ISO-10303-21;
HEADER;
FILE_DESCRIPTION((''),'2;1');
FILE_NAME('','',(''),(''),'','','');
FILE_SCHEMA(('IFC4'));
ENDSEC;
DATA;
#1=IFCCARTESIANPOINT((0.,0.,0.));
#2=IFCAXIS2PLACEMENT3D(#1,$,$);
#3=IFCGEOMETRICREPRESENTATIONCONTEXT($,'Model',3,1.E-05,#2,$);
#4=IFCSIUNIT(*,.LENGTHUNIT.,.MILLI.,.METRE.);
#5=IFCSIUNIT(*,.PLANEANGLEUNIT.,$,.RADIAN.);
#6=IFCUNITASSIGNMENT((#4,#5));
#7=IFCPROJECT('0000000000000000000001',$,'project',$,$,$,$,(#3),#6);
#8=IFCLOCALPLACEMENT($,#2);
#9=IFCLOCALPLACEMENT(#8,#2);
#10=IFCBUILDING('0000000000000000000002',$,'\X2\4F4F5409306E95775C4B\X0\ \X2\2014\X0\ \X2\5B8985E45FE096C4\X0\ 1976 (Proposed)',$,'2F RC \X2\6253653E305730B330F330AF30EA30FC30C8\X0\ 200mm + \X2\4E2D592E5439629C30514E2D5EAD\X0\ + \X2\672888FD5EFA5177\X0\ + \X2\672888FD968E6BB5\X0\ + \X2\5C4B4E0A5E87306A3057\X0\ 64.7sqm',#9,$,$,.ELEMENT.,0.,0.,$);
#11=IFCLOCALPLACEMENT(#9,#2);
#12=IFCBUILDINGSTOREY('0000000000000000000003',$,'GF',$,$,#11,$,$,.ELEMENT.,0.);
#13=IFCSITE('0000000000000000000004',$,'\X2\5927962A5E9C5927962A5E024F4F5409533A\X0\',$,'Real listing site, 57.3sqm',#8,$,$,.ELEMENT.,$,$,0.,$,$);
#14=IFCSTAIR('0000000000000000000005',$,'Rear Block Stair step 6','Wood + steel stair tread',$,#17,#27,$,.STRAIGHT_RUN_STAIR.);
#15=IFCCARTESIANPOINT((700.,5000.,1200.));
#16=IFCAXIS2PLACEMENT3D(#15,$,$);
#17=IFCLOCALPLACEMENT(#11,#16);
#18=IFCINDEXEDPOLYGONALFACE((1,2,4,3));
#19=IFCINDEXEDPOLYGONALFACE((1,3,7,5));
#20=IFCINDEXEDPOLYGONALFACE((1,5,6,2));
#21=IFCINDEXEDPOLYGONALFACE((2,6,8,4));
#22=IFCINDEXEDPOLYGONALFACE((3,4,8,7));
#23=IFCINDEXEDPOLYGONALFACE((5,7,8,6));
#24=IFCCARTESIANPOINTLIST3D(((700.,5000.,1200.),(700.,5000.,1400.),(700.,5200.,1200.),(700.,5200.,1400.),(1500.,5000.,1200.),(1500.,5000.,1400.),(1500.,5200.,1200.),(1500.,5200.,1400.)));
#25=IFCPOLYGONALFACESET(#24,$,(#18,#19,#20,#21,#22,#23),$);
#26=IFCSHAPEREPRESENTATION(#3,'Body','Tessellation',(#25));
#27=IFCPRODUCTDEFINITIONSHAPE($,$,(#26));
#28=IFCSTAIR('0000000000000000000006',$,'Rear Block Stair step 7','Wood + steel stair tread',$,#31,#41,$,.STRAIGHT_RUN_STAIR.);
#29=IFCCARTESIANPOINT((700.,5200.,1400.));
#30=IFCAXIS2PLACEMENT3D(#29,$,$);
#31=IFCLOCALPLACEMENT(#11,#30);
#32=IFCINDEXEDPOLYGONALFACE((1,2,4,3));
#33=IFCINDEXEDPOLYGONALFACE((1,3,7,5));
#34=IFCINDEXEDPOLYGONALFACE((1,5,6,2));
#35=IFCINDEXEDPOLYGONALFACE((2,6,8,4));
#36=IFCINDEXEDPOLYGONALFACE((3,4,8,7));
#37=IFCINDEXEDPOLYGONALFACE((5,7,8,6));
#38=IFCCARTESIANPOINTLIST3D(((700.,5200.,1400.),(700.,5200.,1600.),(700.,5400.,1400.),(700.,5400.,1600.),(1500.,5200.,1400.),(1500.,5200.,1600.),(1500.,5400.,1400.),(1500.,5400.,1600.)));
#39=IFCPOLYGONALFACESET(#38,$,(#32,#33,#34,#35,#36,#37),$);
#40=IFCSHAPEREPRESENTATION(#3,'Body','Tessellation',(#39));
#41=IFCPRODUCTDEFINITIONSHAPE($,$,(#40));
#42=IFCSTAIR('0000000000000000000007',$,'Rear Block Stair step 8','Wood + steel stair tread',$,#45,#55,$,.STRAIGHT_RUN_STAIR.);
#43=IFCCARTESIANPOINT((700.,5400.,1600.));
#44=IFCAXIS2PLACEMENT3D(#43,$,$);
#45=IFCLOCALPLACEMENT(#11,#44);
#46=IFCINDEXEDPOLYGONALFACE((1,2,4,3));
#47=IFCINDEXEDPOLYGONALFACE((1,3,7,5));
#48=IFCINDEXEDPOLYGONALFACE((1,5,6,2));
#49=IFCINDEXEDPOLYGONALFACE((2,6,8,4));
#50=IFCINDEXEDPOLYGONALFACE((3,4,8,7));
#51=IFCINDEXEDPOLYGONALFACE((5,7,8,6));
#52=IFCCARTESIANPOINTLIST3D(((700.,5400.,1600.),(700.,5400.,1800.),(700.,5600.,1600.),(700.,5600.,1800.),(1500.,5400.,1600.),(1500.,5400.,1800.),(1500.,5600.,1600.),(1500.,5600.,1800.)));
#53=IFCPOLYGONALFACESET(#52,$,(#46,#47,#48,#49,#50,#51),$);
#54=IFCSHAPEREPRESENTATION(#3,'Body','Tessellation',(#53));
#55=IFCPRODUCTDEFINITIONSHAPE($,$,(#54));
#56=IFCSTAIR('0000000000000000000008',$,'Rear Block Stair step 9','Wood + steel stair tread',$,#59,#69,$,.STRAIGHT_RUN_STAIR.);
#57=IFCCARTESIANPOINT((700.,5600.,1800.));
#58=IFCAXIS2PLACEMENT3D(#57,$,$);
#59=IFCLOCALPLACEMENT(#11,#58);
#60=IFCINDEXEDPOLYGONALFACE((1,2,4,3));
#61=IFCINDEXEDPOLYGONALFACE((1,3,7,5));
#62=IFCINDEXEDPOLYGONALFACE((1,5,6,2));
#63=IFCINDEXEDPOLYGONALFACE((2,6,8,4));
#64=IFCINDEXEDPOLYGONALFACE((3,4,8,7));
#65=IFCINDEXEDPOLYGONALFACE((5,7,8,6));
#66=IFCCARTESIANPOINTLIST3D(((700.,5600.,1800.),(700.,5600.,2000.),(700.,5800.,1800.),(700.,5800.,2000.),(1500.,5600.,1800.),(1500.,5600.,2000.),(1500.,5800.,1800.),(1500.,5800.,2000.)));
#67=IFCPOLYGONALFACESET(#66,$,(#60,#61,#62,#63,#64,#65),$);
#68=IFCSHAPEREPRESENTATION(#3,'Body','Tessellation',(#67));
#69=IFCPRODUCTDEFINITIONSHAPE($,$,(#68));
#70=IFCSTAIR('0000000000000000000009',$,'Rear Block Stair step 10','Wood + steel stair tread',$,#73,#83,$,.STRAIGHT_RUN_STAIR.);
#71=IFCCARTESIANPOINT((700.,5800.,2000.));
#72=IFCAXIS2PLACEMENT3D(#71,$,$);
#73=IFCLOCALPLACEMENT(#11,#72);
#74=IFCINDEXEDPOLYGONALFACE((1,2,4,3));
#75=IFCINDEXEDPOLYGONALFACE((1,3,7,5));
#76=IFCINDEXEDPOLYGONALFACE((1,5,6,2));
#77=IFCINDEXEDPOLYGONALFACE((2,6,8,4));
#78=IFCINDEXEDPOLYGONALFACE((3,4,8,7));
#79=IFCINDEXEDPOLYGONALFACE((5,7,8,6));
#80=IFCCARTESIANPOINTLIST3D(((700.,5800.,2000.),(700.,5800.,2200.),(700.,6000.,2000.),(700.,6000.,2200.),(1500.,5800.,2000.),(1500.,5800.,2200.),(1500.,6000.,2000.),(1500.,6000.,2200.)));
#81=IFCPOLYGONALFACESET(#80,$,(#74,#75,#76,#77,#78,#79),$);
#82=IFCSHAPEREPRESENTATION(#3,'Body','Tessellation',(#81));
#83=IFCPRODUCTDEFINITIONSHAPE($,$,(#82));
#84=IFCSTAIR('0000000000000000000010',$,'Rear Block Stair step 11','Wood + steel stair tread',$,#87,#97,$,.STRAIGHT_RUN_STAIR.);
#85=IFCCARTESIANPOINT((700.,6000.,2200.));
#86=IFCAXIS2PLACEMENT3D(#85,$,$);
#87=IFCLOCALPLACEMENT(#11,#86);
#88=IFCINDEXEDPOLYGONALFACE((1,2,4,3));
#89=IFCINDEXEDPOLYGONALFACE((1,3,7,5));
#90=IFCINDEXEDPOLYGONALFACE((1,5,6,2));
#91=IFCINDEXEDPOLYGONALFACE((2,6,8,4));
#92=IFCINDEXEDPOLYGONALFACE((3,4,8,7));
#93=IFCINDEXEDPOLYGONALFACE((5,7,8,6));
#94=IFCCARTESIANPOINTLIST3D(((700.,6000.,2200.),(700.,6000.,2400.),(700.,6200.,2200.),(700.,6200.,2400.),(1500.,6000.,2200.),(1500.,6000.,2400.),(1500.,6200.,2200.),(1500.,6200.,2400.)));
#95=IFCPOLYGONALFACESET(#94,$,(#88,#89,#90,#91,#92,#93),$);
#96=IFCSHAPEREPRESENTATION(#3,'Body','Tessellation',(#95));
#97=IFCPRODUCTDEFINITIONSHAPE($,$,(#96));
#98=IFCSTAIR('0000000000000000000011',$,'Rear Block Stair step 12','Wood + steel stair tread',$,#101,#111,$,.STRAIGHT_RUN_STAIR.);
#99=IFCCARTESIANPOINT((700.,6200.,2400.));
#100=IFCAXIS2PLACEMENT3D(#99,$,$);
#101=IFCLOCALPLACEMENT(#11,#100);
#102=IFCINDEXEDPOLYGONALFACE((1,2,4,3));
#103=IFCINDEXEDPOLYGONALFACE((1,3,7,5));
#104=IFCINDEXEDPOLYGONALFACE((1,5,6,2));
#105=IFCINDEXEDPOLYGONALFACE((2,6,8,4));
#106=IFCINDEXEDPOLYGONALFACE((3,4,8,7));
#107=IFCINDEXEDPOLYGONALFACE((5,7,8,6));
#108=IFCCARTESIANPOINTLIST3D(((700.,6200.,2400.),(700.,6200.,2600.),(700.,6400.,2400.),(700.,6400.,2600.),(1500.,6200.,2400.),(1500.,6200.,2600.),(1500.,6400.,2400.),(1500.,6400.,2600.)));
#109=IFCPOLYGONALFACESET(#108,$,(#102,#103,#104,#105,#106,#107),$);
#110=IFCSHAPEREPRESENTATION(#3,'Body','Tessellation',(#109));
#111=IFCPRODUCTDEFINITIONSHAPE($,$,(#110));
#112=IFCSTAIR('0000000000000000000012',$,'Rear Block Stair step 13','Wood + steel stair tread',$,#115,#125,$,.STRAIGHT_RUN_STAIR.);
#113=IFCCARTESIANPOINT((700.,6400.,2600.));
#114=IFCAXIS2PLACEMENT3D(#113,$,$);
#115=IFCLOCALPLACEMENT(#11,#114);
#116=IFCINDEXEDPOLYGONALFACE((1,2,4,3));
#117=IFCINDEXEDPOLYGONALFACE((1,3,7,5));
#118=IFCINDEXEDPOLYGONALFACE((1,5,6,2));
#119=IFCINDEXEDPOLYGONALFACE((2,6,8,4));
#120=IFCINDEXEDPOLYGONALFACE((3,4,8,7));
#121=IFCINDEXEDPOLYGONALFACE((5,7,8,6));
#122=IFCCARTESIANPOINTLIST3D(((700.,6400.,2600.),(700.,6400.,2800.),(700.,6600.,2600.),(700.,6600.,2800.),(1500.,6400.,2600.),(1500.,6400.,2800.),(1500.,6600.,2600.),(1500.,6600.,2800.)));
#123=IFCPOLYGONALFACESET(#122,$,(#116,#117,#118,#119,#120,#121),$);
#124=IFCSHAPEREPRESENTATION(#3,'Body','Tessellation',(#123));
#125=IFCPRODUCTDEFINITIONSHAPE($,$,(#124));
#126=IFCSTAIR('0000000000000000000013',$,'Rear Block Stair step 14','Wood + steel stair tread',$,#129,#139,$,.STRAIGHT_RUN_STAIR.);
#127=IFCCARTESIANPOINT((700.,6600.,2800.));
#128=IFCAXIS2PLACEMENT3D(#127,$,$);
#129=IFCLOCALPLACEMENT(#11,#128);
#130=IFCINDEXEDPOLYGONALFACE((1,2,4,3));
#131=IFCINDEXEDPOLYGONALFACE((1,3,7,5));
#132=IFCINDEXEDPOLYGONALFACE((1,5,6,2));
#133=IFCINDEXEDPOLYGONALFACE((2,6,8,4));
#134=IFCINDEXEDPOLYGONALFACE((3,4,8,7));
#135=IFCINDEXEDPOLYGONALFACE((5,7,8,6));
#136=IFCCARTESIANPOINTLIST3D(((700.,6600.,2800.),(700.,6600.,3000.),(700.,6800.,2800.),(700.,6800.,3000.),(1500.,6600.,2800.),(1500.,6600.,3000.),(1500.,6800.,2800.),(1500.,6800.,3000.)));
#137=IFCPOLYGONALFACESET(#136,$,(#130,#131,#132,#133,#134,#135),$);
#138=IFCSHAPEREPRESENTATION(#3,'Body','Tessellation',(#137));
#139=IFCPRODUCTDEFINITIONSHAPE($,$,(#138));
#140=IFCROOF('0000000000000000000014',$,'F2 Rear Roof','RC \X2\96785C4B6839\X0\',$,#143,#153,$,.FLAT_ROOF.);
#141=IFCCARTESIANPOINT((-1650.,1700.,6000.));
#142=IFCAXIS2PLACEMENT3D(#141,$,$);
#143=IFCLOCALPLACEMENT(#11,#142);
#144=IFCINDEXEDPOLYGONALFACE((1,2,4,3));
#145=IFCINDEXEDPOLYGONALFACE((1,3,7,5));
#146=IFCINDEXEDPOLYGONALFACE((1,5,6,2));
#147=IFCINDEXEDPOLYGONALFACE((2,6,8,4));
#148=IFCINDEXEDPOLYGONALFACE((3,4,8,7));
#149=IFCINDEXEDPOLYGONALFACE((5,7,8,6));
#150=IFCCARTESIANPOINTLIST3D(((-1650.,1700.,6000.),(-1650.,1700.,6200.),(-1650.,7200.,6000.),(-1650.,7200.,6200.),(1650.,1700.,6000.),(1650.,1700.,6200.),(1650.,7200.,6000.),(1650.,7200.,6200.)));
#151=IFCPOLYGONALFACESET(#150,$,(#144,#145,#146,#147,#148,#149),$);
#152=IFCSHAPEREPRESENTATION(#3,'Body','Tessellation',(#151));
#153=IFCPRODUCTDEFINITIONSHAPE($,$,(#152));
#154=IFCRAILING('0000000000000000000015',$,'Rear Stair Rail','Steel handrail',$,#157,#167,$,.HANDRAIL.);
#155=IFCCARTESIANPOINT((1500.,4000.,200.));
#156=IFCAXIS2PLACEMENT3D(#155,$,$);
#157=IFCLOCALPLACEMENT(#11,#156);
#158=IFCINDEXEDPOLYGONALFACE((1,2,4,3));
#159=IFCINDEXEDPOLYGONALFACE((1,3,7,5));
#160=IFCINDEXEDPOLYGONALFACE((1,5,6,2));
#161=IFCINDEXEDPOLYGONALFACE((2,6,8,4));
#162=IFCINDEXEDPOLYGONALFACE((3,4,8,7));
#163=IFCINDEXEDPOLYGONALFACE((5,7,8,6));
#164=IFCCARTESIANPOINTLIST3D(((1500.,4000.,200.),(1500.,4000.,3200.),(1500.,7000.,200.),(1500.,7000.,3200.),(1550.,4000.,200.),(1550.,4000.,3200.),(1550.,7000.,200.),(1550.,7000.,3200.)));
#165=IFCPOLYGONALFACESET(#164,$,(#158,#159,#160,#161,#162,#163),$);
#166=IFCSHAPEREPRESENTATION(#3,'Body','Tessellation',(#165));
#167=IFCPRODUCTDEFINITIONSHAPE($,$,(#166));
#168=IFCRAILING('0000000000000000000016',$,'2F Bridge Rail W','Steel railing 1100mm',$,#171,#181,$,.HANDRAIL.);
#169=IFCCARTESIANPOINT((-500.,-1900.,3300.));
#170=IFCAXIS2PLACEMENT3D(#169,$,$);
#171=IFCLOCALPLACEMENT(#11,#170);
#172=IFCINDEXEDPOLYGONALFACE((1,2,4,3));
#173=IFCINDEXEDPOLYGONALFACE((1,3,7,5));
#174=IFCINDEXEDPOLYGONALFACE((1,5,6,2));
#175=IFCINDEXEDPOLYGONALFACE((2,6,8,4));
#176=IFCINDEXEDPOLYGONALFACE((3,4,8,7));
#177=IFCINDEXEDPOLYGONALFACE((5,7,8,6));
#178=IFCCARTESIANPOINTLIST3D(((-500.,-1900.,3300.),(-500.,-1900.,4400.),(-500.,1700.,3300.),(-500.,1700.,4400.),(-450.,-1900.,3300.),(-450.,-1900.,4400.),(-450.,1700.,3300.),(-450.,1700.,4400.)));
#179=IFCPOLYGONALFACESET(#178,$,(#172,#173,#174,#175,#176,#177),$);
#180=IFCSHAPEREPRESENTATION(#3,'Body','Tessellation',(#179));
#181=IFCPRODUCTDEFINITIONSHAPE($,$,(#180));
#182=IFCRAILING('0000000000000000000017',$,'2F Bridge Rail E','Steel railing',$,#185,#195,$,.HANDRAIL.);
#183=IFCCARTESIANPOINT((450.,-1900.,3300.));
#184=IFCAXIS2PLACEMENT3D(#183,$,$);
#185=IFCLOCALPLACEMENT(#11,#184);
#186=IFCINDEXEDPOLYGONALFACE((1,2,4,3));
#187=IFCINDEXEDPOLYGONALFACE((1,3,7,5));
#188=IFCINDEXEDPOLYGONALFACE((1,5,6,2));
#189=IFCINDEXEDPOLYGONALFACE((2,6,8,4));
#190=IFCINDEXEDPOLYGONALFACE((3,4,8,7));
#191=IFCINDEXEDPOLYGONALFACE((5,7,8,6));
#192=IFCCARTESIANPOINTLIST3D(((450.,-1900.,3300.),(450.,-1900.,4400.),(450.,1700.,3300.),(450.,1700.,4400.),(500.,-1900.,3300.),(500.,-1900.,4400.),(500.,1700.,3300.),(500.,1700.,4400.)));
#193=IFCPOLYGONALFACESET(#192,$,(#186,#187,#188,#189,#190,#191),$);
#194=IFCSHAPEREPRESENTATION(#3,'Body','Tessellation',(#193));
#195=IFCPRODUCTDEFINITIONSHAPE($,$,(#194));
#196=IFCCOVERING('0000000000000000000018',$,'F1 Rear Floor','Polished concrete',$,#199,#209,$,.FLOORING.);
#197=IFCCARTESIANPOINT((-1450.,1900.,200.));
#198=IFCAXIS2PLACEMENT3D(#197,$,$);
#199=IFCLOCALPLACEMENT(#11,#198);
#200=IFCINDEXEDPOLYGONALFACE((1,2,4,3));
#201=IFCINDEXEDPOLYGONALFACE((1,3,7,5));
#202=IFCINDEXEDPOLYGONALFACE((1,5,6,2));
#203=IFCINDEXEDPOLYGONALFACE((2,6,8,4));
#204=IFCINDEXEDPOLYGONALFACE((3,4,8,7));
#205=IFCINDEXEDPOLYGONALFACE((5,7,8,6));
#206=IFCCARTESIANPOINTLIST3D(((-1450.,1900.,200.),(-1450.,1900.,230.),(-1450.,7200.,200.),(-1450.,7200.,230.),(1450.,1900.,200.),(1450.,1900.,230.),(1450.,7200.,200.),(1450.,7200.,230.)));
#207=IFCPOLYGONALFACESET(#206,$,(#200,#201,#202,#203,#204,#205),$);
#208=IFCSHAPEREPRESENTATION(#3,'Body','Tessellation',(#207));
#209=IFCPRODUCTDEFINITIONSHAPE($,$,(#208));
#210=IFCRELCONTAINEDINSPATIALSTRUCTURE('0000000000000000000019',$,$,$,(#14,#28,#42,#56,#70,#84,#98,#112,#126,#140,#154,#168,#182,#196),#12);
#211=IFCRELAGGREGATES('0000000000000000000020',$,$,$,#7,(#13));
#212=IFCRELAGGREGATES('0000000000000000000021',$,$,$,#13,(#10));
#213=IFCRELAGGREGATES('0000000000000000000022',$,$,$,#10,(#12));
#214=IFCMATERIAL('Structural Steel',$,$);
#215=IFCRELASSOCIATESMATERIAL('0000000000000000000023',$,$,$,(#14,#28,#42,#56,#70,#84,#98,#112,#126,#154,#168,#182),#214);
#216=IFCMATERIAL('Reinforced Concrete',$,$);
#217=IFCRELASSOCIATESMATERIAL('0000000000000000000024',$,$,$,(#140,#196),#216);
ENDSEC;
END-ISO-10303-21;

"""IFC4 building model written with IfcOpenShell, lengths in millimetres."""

from ifc_helpers import new_model, si_unit, frame, frame_2d, origin, place, context, project, spatial, rectangle, extrude, material, element, save


model = new_model("IFC4")

# Units and contexts
model_context = context("Model", 3, precision=1e-05, world=origin())
ifc_project = project(units=[si_unit("LENGTHUNIT", "METRE", prefix="MILLI"), si_unit("PLANEANGLEUNIT", "RADIAN")], contexts=[model_context])

# Site, building, storey
site_placement = place(None, origin())
site = spatial("IfcSite", under=ifc_project, at=site_placement, Name="大阪府大阪市住吉区", ObjectType="Real listing site, 57.3sqm", CompositionType="ELEMENT", RefElevation=0.0)
building_placement = place(site_placement, origin())
building = spatial("IfcBuilding", under=site, at=building_placement, Name="住吉の長屋 — 安藤忠雄 1976 (Proposed)", ObjectType="2F RC 打放しコンクリート 200mm + 中央吹抜け中庭 + 木製建具 + 木製階段 + 屋上庇なし 64.7sqm", CompositionType="ELEMENT", ElevationOfRefHeight=0.0, ElevationOfTerrain=0.0)
storey_placement = place(building_placement, origin())
storey = spatial("IfcBuildingStorey", under=building, at=storey_placement, Name="GF", CompositionType="ELEMENT", Elevation=0.0)

# Shared definitions
ifc_material_1 = material(Name="Reinforced Concrete")

# Stairs
ifc_material_2 = material(Name="Structural Steel")
stair_1_placement = place(storey_placement, frame((700.0, 5000.0, 1200.0)))
element("IfcStair", 1, at=stair_1_placement, inside=storey, material=ifc_material_2, Name="Rear Block Stair step 6", Description="Wood + steel stair tread", PredefinedType="STRAIGHT_RUN_STAIR", context=model_context, shape_type="SweptSolid", body=[
    extrude(rectangle(XDim=800.0, YDim=200.0, at=frame_2d((400.0, 100.0))), frame((700.0, 5000.0, 1200.0)), (0.0, 0.0, 1.0), 200.0),
])
stair_2_placement = place(storey_placement, frame((700.0, 5200.0, 1400.0)))
element("IfcStair", 2, at=stair_2_placement, inside=storey, material=ifc_material_2, Name="Rear Block Stair step 7", Description="Wood + steel stair tread", PredefinedType="STRAIGHT_RUN_STAIR", context=model_context, shape_type="SweptSolid", body=[
    extrude(rectangle(XDim=800.0, YDim=200.0, at=frame_2d((400.0, 100.0))), frame((700.0, 5200.0, 1400.0)), (0.0, 0.0, 1.0), 200.0),
])
stair_3_placement = place(storey_placement, frame((700.0, 5400.0, 1600.0)))
element("IfcStair", 3, at=stair_3_placement, inside=storey, material=ifc_material_2, Name="Rear Block Stair step 8", Description="Wood + steel stair tread", PredefinedType="STRAIGHT_RUN_STAIR", context=model_context, shape_type="SweptSolid", body=[
    extrude(rectangle(XDim=800.0, YDim=200.0, at=frame_2d((400.0, 100.0))), frame((700.0, 5400.0, 1600.0)), (0.0, 0.0, 1.0), 200.0),
])
stair_4_placement = place(storey_placement, frame((700.0, 5600.0, 1800.0)))
element("IfcStair", 4, at=stair_4_placement, inside=storey, material=ifc_material_2, Name="Rear Block Stair step 9", Description="Wood + steel stair tread", PredefinedType="STRAIGHT_RUN_STAIR", context=model_context, shape_type="SweptSolid", body=[
    extrude(rectangle(XDim=800.0, YDim=200.0, at=frame_2d((400.0, 100.0))), frame((700.0, 5600.0, 1800.0)), (0.0, 0.0, 1.0), 200.0),
])
stair_5_placement = place(storey_placement, frame((700.0, 5800.0, 2000.0)))
element("IfcStair", 5, at=stair_5_placement, inside=storey, material=ifc_material_2, Name="Rear Block Stair step 10", Description="Wood + steel stair tread", PredefinedType="STRAIGHT_RUN_STAIR", context=model_context, shape_type="SweptSolid", body=[
    extrude(rectangle(XDim=800.0, YDim=200.0, at=frame_2d((400.0, 100.0))), frame((700.0, 5800.0, 2000.0)), (0.0, 0.0, 1.0), 200.0),
])
stair_6_placement = place(storey_placement, frame((700.0, 6000.0, 2200.0)))
element("IfcStair", 6, at=stair_6_placement, inside=storey, material=ifc_material_2, Name="Rear Block Stair step 11", Description="Wood + steel stair tread", PredefinedType="STRAIGHT_RUN_STAIR", context=model_context, shape_type="SweptSolid", body=[
    extrude(rectangle(XDim=800.0, YDim=200.0, at=frame_2d((400.0, 100.0))), frame((700.0, 6000.0, 2200.0)), (0.0, 0.0, 1.0), 200.0),
])
stair_7_placement = place(storey_placement, frame((700.0, 6200.0, 2400.0)))
element("IfcStair", 7, at=stair_7_placement, inside=storey, material=ifc_material_2, Name="Rear Block Stair step 12", Description="Wood + steel stair tread", PredefinedType="STRAIGHT_RUN_STAIR", context=model_context, shape_type="SweptSolid", body=[
    extrude(rectangle(XDim=800.0, YDim=200.0, at=frame_2d((400.0, 100.0))), frame((700.0, 6200.0, 2400.0)), (0.0, 0.0, 1.0), 200.0),
])
stair_8_placement = place(storey_placement, frame((700.0, 6400.0, 2600.0)))
element("IfcStair", 8, at=stair_8_placement, inside=storey, material=ifc_material_2, Name="Rear Block Stair step 13", Description="Wood + steel stair tread", PredefinedType="STRAIGHT_RUN_STAIR", context=model_context, shape_type="SweptSolid", body=[
    extrude(rectangle(XDim=800.0, YDim=200.0, at=frame_2d((400.0, 100.0))), frame((700.0, 6400.0, 2600.0)), (0.0, 0.0, 1.0), 200.0),
])
stair_9_placement = place(storey_placement, frame((700.0, 6600.0, 2800.0)))
element("IfcStair", 9, at=stair_9_placement, inside=storey, material=ifc_material_2, Name="Rear Block Stair step 14", Description="Wood + steel stair tread", PredefinedType="STRAIGHT_RUN_STAIR", context=model_context, shape_type="SweptSolid", body=[
    extrude(rectangle(XDim=800.0, YDim=200.0, at=frame_2d((400.0, 100.0))), frame((700.0, 6600.0, 2800.0)), (0.0, 0.0, 1.0), 200.0),
])

# Roof
roof_placement = place(storey_placement, frame((-1650.0, 1700.0, 6000.0)))
element("IfcRoof", 10, at=roof_placement, inside=storey, material=ifc_material_1, Name="F2 Rear Roof", Description="RC 陸屋根", PredefinedType="FLAT_ROOF", context=model_context, shape_type="SweptSolid", body=[
    extrude(rectangle(XDim=3300.0, YDim=5500.0, at=frame_2d((1650.0, 2750.0))), frame((-1650.0, 1700.0, 6000.0)), (0.0, 0.0, 1.0), 200.0),
])

# Railings
railing_1_placement = place(storey_placement, frame((1500.0, 4000.0, 200.0)))
element("IfcRailing", 11, at=railing_1_placement, inside=storey, material=ifc_material_2, Name="Rear Stair Rail", Description="Steel handrail", PredefinedType="HANDRAIL", context=model_context, shape_type="SweptSolid", body=[
    extrude(rectangle(XDim=50.0, YDim=3000.0, at=frame_2d((25.0, 1500.0))), frame((1500.0, 4000.0, 200.0)), (0.0, 0.0, 1.0), 3000.0),
])
railing_2_placement = place(storey_placement, frame((-500.0, -1900.0, 3300.0)))
element("IfcRailing", 12, at=railing_2_placement, inside=storey, material=ifc_material_2, Name="2F Bridge Rail W", Description="Steel railing 1100mm", PredefinedType="HANDRAIL", context=model_context, shape_type="SweptSolid", body=[
    extrude(rectangle(XDim=50.0, YDim=3600.0, at=frame_2d((25.0, 1800.0))), frame((-500.0, -1900.0, 3300.0)), (0.0, 0.0, 1.0), 1100.0),
])
railing_3_placement = place(storey_placement, frame((450.0, -1900.0, 3300.0)))
element("IfcRailing", 13, at=railing_3_placement, inside=storey, material=ifc_material_2, Name="2F Bridge Rail E", Description="Steel railing", PredefinedType="HANDRAIL", context=model_context, shape_type="SweptSolid", body=[
    extrude(rectangle(XDim=50.0, YDim=3600.0, at=frame_2d((25.0, 1800.0))), frame((450.0, -1900.0, 3300.0)), (0.0, 0.0, 1.0), 1100.0),
])

# Covering
covering_placement = place(storey_placement, frame((-1450.0, 1900.0, 200.0)))
element("IfcCovering", 14, at=covering_placement, inside=storey, material=ifc_material_1, Name="F1 Rear Floor", Description="Polished concrete", PredefinedType="FLOORING", context=model_context, shape_type="SweptSolid", body=[
    extrude(rectangle(XDim=2900.0, YDim=5300.0, at=frame_2d((1450.0, 2650.0))), frame((-1450.0, 1900.0, 200.0)), (0.0, 0.0, 1.0), 30.0),
])

save(model, "model.ifc")
